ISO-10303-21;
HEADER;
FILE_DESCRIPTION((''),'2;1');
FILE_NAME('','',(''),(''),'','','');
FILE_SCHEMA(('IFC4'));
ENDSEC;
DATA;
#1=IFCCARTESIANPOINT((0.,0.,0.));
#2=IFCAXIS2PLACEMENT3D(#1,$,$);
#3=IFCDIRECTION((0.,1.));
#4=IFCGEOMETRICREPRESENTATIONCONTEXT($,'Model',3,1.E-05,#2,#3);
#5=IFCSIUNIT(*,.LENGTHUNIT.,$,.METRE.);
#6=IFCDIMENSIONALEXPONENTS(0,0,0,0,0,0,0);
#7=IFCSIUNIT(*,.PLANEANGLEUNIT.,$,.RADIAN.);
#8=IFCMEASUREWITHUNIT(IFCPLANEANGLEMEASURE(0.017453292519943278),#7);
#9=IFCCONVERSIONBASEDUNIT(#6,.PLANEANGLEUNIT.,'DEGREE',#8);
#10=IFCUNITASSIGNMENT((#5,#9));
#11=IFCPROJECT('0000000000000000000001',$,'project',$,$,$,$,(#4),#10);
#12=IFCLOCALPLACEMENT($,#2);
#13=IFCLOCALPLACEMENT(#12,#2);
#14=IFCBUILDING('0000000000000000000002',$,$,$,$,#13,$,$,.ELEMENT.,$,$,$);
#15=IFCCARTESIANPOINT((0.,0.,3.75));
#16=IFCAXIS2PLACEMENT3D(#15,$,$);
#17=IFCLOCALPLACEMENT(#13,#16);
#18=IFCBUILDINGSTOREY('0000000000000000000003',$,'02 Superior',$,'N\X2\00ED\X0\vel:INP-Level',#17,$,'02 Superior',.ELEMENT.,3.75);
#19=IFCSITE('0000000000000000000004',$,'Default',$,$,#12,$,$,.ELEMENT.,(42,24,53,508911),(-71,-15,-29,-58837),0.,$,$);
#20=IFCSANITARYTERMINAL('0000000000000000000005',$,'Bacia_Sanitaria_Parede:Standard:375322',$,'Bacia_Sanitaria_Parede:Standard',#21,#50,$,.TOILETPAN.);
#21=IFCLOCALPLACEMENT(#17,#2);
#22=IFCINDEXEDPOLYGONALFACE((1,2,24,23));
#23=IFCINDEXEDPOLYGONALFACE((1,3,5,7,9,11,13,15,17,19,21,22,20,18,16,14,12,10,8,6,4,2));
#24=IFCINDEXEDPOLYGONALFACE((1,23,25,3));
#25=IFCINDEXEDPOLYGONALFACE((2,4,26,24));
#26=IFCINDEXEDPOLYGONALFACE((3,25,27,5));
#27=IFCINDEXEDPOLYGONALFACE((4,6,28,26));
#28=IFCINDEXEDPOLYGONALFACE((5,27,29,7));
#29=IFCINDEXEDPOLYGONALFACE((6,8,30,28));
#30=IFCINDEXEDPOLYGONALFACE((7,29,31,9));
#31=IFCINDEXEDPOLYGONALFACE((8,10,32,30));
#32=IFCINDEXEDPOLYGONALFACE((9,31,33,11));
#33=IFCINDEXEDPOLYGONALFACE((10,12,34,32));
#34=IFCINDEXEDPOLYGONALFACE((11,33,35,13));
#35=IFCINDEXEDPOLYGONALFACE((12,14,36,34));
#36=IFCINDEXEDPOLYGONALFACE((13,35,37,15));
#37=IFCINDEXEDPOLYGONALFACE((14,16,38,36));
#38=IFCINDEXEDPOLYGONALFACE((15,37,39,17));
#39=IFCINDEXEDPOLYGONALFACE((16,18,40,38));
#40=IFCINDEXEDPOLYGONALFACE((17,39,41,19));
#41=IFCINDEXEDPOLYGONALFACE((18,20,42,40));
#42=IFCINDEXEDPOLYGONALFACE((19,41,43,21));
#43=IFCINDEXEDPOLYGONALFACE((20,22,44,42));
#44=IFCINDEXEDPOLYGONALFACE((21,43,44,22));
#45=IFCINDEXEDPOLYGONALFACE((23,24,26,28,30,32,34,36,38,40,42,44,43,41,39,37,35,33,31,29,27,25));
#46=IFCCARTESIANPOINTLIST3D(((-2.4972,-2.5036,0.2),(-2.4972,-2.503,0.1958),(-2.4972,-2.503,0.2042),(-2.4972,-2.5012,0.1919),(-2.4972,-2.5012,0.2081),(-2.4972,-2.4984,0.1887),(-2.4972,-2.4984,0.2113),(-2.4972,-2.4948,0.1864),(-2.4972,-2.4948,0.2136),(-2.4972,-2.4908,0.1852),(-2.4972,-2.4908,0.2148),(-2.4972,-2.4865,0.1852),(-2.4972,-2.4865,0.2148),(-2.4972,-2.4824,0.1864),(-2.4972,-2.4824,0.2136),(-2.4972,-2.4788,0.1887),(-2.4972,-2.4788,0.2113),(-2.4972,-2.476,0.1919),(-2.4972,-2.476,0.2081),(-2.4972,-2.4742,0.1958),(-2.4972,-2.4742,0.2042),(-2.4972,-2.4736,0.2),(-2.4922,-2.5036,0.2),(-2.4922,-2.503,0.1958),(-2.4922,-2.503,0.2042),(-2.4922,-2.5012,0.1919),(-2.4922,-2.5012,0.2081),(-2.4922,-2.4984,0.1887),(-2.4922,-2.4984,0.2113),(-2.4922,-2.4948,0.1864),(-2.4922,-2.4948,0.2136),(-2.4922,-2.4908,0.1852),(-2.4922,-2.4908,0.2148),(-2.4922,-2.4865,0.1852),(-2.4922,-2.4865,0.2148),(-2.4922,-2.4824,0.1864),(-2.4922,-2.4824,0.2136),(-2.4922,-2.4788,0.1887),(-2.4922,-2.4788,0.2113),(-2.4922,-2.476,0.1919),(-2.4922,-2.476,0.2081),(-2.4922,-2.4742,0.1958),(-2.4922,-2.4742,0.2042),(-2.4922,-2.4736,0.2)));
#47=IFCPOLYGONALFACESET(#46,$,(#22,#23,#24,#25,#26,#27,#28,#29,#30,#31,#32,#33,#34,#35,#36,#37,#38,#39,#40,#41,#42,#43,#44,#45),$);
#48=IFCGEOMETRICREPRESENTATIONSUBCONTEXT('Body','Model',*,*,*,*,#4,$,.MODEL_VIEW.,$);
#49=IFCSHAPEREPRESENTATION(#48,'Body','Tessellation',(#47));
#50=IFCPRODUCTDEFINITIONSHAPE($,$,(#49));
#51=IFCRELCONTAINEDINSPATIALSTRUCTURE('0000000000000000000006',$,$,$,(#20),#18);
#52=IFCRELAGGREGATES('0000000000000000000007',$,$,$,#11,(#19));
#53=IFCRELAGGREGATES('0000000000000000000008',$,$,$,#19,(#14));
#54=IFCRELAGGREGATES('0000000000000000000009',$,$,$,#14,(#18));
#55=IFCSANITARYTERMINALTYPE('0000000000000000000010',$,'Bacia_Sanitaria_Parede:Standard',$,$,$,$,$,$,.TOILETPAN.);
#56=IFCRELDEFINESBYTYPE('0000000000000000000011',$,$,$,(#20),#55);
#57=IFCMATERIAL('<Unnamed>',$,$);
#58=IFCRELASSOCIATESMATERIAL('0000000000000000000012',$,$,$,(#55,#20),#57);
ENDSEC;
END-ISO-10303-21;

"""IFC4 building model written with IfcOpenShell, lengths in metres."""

from ifc_helpers import new_model, entity, si_unit, converted_unit, direction, frame, origin, place, context, subcontext, project, spatial, arc, indexed_curve, outline, extrude, source, transform, mapped, material, type_object, type_shapes, element, save


model = new_model("IFC4")

# Units and contexts
model_context = context("Model", 3, precision=1e-05, world=origin(), true_north=direction((0.0, 1.0)))
body_context = subcontext(model_context, "Body", "Model", "MODEL_VIEW")
ifc_project = project(units=[si_unit("LENGTHUNIT", "METRE"), converted_unit("PLANEANGLEUNIT", "DEGREE", entity("IfcPlaneAngleMeasure", 0.017453292519943278), si_unit("PLANEANGLEUNIT", "RADIAN"), dimensions=[0, 0, 0, 0, 0, 0, 0])], contexts=[model_context])

# Site, building, storey
site_placement = place(None, origin())
site = spatial("IfcSite", under=ifc_project, at=site_placement, Name="Default", CompositionType="ELEMENT", RefLatitude=(42, 24, 53, 508911), RefLongitude=(-71, -15, -29, -58837), RefElevation=0.0)
building_placement = place(site_placement, origin())
building = spatial("IfcBuilding", under=site, at=building_placement, CompositionType="ELEMENT")
storey_placement = place(building_placement, frame((0.0, 0.0, 3.75)))
storey = spatial("IfcBuildingStorey", under=building, at=storey_placement, Name="02 Superior", ObjectType="Nível:INP-Level", LongName="02 Superior", CompositionType="ELEMENT", Elevation=3.75)

# Sanitary terminal
ifc_material = material(Name="<Unnamed>")
sanitary_terminal_type = type_object("IfcSanitaryTerminalType", Name="Bacia_Sanitaria_Parede:Standard", PredefinedType="TOILETPAN", material=ifc_material)
shared_shape = source(origin(), body_context, "Body", "SweptSolid", [
    extrude(outline(indexed_curve([(-0.015, 0.0), (0.0, -0.015), (0.015, 0.0), (0.0, 0.015)], segments=[arc(1, 2, 3), arc(3, 4, 1)], self_intersect=False)), frame((0.15, -0.005, 0.2), z_axis=(0.0, 1.0, 0.0), x_axis=(1.0, 0.0, 0.0)), (0.0, 0.0, 1.0), 0.005),
])
type_shapes(sanitary_terminal_type, [shared_shape])
for number, where, z_axis, x_axis, name in (
    (1, (-2.4972, -2.6386, 0.0), (0.0, 0.0, 1.0), (0.0, 1.0, 0.0), "Bacia_Sanitaria_Parede:Standard:375322"),
):
    element("IfcSanitaryTerminal", number, at=place(storey_placement, frame(where, z_axis=z_axis, x_axis=x_axis)), inside=storey, type_object=sanitary_terminal_type, material=ifc_material, Name=name, ObjectType="Bacia_Sanitaria_Parede:Standard", PredefinedType="TOILETPAN", context=body_context, shape_type="MappedRepresentation", body=[
        mapped(shared_shape, transform((0.0, 0.0, 0.0), scale=1.0)),
    ])

save(model, "model.ifc")
